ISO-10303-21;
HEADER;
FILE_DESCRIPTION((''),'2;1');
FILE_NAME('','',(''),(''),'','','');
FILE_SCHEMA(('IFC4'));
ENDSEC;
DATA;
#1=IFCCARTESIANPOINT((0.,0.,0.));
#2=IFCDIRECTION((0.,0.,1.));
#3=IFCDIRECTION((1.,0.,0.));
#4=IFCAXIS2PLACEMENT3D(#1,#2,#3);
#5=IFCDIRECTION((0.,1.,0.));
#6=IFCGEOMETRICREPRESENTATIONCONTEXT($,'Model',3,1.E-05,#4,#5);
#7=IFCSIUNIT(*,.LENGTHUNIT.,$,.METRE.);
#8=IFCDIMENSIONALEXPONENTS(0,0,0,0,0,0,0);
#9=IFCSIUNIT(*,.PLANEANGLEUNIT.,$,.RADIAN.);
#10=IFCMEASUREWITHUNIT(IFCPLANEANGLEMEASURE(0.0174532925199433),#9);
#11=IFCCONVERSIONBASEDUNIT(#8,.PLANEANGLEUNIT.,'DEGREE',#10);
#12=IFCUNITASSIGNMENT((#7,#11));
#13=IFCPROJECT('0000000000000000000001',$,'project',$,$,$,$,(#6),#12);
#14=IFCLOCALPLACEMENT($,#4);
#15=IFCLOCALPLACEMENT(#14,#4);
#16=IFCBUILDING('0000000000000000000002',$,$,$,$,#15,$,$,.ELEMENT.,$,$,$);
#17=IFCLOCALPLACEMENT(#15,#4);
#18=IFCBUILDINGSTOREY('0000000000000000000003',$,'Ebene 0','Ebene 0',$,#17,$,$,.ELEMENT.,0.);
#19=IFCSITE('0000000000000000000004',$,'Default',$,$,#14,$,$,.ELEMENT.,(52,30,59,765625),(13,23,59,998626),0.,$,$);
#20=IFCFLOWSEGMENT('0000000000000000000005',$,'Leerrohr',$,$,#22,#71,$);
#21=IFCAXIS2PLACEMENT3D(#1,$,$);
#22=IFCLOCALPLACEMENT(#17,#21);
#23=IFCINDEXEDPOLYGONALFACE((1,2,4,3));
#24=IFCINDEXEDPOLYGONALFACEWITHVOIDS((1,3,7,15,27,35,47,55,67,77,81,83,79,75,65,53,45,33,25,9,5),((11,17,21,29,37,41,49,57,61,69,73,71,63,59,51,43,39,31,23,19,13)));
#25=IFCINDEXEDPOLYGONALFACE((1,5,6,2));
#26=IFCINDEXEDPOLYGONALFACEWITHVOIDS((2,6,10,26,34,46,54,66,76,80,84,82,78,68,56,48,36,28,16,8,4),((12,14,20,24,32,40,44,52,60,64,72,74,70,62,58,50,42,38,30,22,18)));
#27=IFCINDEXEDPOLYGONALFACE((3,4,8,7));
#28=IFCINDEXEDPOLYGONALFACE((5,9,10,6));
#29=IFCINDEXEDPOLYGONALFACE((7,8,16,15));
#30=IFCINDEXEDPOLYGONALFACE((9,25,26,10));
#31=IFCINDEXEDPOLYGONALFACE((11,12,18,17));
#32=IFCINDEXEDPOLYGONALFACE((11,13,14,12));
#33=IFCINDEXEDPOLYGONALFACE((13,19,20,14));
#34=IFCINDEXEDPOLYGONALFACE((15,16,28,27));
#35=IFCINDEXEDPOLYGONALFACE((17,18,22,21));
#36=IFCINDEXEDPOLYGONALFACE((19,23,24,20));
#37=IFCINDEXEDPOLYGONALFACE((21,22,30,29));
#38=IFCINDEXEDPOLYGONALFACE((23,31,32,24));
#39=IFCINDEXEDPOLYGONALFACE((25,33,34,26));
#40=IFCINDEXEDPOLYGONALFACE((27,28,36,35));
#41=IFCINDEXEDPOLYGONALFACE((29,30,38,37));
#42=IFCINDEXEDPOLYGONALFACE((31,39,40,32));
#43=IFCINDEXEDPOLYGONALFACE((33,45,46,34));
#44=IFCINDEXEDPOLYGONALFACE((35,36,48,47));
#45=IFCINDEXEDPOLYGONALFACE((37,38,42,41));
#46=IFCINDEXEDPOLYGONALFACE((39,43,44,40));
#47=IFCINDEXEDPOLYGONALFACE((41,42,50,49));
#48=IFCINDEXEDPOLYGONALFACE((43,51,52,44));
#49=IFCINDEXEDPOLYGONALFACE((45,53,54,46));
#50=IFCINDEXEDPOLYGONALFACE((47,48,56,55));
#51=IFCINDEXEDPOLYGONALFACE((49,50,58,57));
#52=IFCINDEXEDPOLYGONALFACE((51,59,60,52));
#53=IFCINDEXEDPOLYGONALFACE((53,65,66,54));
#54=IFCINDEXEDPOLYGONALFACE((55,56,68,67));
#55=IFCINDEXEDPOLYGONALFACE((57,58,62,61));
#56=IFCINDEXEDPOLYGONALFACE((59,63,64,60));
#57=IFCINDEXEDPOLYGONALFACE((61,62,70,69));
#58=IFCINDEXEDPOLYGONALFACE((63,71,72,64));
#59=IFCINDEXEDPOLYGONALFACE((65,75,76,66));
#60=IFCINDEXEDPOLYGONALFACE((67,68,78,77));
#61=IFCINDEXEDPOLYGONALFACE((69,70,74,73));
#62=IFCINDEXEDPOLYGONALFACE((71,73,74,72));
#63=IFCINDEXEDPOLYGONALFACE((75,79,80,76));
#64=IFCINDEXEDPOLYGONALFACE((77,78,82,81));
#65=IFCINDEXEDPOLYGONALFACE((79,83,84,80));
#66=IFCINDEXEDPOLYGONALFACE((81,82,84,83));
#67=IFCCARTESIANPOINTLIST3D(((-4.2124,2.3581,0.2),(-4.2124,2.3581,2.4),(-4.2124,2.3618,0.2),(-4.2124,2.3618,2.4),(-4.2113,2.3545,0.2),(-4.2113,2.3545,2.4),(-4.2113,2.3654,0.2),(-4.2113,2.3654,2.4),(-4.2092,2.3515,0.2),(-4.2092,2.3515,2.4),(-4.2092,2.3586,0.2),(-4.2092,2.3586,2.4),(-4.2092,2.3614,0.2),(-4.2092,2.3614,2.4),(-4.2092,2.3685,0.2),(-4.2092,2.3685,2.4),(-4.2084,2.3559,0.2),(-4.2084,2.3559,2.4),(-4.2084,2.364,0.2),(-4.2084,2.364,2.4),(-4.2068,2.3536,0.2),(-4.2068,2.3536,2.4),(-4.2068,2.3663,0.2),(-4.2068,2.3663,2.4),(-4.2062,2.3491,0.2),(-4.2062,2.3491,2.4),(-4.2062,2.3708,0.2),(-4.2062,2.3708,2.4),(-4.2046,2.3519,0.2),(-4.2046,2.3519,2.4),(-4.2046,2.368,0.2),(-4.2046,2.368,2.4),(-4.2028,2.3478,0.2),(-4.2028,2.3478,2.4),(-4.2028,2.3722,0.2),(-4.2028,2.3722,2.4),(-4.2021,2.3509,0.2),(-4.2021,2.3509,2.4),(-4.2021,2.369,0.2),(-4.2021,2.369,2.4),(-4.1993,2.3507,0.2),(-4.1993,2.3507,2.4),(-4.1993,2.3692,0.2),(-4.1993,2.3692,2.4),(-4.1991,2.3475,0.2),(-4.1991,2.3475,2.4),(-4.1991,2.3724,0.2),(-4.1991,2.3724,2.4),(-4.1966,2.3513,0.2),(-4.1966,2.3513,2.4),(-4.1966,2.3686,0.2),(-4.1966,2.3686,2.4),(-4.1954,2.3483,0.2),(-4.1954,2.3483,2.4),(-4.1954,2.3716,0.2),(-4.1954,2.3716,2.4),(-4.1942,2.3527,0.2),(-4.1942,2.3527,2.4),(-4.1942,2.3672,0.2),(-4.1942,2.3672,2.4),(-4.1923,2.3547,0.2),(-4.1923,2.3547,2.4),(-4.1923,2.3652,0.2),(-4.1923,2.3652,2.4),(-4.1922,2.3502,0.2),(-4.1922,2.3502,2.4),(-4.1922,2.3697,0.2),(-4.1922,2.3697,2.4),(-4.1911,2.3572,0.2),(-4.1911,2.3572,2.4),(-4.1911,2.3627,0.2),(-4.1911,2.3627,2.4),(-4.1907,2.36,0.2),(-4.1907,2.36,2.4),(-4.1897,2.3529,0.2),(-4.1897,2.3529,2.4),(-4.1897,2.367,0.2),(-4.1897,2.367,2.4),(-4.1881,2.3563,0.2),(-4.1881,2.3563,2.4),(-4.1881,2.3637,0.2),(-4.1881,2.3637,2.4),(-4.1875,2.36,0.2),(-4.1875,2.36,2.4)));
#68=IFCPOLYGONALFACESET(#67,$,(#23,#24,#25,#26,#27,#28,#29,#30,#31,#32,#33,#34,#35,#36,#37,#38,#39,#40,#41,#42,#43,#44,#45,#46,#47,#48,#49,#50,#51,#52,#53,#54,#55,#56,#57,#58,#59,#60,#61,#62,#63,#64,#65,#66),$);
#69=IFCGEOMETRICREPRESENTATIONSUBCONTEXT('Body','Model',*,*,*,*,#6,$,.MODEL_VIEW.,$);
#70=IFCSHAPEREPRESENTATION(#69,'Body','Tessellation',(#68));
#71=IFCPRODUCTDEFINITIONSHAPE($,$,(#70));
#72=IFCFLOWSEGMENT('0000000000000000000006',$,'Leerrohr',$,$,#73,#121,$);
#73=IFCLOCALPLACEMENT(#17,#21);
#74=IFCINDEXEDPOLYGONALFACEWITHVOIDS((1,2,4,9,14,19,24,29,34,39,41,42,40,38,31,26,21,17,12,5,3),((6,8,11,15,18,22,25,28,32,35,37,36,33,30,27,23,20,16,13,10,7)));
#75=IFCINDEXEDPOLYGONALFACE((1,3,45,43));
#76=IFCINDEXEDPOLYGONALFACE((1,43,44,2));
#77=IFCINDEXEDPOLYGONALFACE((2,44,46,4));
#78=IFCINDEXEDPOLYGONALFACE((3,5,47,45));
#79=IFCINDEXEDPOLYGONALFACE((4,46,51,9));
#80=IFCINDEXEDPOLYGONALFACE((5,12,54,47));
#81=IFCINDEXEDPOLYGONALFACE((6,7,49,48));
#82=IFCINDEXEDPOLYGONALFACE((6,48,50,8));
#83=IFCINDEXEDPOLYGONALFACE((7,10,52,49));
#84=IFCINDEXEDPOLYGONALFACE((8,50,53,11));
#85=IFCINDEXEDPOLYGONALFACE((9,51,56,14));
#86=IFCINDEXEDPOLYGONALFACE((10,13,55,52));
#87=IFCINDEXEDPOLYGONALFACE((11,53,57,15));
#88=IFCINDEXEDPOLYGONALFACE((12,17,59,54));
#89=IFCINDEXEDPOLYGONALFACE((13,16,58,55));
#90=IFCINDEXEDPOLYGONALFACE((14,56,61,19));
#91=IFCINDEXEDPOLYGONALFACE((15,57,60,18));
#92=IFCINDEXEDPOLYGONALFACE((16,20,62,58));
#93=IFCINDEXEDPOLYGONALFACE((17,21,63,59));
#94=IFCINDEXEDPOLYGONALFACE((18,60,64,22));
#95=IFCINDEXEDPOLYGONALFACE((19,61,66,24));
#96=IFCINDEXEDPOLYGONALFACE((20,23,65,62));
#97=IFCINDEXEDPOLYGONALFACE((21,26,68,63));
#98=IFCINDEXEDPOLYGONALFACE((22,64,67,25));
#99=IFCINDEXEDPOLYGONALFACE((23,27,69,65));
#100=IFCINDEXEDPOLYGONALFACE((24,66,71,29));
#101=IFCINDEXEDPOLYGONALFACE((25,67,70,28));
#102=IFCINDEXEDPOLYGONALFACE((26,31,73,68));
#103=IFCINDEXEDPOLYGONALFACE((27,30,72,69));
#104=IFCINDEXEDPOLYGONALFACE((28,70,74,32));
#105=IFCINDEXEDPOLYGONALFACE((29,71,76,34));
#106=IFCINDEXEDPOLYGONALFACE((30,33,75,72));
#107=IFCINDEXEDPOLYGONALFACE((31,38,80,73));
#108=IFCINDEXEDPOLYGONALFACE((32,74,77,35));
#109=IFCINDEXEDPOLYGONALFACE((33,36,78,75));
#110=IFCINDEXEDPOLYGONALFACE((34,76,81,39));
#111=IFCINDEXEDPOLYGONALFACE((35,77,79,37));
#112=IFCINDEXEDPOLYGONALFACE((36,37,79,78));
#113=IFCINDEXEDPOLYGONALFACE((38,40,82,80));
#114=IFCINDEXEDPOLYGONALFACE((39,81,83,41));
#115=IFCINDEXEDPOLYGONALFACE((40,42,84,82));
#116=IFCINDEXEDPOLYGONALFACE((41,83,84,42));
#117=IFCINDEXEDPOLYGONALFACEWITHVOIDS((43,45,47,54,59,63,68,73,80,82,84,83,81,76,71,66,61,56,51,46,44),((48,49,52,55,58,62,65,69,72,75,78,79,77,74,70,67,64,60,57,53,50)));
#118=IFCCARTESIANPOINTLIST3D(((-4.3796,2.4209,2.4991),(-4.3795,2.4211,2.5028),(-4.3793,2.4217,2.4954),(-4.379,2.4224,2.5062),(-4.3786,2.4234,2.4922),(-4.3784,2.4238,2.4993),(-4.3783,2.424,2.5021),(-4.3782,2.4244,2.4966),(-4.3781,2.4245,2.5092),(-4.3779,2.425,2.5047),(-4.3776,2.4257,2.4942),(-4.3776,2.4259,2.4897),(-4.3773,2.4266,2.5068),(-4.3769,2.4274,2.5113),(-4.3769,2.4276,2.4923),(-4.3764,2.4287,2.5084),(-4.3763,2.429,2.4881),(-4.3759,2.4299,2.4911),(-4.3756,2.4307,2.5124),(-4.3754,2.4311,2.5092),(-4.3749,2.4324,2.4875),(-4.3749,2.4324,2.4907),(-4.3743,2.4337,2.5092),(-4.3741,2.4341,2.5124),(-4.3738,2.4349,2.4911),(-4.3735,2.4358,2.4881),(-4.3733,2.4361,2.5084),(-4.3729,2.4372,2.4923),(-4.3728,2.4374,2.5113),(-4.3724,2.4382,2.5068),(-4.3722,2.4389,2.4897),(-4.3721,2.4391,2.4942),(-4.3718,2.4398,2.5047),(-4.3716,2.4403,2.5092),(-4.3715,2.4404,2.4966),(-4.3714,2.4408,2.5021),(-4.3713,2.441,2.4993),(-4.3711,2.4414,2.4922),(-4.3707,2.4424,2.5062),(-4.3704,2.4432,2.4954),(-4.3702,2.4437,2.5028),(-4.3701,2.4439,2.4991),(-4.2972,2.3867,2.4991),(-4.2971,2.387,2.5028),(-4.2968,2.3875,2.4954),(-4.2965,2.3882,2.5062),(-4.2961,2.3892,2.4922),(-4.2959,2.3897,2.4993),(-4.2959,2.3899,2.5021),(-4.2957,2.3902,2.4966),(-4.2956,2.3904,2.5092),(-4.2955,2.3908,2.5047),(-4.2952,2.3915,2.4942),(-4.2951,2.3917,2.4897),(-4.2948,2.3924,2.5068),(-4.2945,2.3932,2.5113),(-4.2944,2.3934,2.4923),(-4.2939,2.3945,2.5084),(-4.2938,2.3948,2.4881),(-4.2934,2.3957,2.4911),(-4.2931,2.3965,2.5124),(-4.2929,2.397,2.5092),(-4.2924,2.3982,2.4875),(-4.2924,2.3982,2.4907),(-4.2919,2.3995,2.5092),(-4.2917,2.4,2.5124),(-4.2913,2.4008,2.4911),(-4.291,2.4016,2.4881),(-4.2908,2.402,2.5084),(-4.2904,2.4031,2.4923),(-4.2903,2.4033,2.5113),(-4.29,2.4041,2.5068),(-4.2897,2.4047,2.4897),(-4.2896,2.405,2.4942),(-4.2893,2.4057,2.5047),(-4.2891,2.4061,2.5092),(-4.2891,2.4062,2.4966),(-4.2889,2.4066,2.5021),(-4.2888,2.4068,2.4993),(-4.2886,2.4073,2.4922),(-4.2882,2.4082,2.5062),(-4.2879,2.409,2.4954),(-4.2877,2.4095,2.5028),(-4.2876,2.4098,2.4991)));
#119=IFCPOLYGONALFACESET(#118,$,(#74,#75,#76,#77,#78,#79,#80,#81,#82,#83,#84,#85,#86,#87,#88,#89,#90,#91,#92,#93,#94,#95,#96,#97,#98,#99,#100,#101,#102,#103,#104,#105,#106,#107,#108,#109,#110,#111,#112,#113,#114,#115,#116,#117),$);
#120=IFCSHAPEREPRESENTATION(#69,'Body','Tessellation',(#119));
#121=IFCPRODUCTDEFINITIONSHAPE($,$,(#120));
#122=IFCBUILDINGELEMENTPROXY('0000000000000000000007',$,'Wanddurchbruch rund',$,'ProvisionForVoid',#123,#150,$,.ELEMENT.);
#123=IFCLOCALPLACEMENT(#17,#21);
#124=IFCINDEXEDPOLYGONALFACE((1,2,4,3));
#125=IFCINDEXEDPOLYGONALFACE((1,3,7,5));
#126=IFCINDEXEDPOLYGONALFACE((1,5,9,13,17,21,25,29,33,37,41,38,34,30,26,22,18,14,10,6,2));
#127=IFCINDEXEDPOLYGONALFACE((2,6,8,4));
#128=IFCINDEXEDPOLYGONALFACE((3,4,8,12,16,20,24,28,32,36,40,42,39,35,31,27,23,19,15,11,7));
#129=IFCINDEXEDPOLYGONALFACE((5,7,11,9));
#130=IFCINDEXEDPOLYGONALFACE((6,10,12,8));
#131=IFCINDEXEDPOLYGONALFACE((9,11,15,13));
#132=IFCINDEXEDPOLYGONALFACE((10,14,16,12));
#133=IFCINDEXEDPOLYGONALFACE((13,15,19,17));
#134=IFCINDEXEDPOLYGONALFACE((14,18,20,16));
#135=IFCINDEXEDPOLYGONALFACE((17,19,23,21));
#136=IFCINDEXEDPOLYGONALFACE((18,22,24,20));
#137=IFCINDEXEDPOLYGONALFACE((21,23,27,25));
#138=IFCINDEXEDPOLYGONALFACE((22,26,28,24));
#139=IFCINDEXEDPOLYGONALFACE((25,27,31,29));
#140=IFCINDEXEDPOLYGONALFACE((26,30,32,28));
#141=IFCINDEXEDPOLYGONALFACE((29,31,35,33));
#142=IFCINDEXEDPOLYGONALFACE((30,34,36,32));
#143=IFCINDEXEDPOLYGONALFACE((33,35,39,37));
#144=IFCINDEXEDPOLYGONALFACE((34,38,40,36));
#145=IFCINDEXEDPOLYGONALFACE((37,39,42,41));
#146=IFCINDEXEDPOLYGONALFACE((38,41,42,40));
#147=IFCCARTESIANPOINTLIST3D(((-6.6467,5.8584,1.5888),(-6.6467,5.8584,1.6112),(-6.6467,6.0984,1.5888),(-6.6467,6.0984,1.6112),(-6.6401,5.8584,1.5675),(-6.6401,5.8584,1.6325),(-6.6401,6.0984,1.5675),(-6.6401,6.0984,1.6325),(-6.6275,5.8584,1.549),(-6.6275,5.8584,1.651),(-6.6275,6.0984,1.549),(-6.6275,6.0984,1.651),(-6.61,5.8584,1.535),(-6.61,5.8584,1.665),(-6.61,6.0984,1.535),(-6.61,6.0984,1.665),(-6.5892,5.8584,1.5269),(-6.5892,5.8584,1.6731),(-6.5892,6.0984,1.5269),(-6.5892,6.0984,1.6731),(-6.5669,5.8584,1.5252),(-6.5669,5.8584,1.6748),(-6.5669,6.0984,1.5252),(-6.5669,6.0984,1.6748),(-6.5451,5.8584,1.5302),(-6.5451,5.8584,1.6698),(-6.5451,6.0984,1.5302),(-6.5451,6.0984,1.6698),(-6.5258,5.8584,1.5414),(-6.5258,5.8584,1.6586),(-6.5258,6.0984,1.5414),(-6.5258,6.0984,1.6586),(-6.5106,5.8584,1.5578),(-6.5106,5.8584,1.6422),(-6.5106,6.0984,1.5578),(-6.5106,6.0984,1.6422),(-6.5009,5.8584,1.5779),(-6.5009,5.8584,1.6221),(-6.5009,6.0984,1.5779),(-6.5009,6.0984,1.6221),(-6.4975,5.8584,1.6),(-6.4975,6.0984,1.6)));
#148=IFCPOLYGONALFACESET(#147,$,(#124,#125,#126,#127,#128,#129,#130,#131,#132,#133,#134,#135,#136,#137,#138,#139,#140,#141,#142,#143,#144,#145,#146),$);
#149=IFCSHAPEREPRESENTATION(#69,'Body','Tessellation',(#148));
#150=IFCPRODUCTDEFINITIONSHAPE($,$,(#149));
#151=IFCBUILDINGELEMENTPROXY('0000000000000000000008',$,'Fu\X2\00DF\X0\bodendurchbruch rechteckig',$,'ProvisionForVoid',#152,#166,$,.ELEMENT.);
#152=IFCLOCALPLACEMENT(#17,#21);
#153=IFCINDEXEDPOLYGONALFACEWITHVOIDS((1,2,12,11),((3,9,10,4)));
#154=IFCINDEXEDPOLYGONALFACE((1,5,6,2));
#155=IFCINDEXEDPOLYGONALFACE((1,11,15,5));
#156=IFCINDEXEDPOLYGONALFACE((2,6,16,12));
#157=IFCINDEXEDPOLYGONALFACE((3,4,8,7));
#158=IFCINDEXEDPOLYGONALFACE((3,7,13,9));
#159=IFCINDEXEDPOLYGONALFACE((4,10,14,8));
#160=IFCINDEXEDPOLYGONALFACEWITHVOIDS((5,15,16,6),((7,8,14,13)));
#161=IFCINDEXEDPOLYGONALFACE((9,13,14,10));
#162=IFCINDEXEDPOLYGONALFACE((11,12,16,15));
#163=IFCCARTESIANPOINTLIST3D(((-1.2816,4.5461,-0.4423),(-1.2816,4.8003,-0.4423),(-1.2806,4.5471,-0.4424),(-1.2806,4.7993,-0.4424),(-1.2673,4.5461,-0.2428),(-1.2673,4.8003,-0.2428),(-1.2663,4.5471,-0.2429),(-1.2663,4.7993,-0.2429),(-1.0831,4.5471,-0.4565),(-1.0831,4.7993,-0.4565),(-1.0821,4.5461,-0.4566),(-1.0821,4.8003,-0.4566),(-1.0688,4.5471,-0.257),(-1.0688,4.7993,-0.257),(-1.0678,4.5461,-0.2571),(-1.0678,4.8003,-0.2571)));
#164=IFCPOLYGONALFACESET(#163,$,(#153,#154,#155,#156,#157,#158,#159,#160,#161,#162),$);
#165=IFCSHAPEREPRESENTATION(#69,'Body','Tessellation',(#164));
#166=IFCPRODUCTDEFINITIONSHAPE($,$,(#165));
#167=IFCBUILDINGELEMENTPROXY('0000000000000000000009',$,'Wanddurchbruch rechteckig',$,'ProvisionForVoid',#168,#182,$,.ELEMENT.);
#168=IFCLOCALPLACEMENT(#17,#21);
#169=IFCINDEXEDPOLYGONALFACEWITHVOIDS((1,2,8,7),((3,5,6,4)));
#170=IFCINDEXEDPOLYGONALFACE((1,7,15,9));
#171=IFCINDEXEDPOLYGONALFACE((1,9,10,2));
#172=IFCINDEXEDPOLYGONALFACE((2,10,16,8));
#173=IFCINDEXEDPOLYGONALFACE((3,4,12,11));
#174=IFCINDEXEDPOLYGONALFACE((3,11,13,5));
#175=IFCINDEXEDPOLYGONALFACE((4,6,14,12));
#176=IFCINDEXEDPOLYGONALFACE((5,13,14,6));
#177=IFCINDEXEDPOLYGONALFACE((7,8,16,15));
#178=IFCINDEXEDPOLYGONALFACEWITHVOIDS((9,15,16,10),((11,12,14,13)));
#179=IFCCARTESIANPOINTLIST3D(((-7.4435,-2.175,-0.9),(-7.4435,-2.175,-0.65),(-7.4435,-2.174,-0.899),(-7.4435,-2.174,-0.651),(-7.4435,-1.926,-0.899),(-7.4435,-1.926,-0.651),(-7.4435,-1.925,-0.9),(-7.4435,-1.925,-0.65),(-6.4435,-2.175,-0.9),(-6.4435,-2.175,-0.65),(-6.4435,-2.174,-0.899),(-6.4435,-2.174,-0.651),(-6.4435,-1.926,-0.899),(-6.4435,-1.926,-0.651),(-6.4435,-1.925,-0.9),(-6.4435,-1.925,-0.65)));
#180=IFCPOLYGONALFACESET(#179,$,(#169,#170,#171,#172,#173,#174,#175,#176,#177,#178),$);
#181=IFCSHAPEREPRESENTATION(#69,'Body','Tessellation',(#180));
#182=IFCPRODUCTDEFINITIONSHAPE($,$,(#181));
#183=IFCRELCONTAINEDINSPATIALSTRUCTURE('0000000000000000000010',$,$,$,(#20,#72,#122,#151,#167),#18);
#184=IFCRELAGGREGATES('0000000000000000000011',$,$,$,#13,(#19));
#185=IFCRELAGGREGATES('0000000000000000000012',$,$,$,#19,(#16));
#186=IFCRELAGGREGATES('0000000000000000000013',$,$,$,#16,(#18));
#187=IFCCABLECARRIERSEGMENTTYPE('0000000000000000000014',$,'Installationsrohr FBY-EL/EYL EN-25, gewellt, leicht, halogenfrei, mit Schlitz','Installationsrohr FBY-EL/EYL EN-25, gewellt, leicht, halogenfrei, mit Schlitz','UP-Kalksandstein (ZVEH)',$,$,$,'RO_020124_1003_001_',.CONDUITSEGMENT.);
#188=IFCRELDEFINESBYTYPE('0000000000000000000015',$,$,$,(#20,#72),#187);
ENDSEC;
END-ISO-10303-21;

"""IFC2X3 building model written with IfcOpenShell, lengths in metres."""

from ifc_helpers import new_model, entity, si_unit, converted_unit, direction, frame, origin_with_axes, origin_2d_with_axis, place, context, subcontext, project, spatial, hollow_rectangle, circle, hollow_circle, extrude, source, transform, mapped, type_object, element, save


model = new_model("IFC2X3")

# Units and contexts
model_context = context("Model", 3, precision=1e-05, world=origin_with_axes(), true_north=direction((0.0, 1.0, 0.0)))
body_context = subcontext(model_context, "Body", "Model", "MODEL_VIEW")
ifc_project = project(units=[si_unit("LENGTHUNIT", "METRE"), converted_unit("PLANEANGLEUNIT", "DEGREE", entity("IfcPlaneAngleMeasure", 0.0174532925199433), si_unit("PLANEANGLEUNIT", "RADIAN"), dimensions=[0, 0, 0, 0, 0, 0, 0])], contexts=[model_context])

# Site, building, storey
site_placement = place(None, origin_with_axes())
site = spatial("IfcSite", under=ifc_project, at=site_placement, Name="Default", CompositionType="ELEMENT", RefLatitude=(52, 30, 59, 765625), RefLongitude=(13, 23, 59, 998626), RefElevation=0.0)
building_placement = place(site_placement, origin_with_axes())
building = spatial("IfcBuilding", under=site, at=building_placement, CompositionType="ELEMENT")
storey_placement = place(building_placement, origin_with_axes())
storey = spatial("IfcBuildingStorey", under=building, at=storey_placement, Name="Ebene 0", Description="Ebene 0", CompositionType="ELEMENT", Elevation=0.0)

# Flow segments
cable_carrier_segment_type_1 = type_object("IfcCableCarrierSegmentType", Name="Installationsrohr FBY-EL/EYL EN-25, gewellt, leicht, halogenfrei, mit Schlitz", Description="Installationsrohr FBY-EL/EYL EN-25, gewellt, leicht, halogenfrei, mit Schlitz", ApplicableOccurrence="UP-Kalksandstein (ZVEH)", ElementType="RO_020124_1003_001_", PredefinedType="CONDUITSEGMENT")
flow_segment_1_placement = place(storey_placement, frame((-4.2, 2.36, 0.2), z_axis=(-1.0, 0.0, 0.0), x_axis=(0.0, 0.0, 1.0)))
element("IfcFlowSegment", 1, at=flow_segment_1_placement, inside=storey, type_object=cable_carrier_segment_type_1, Name="Leerrohr", context=body_context, shape_type="SweptSolid", body=[
    extrude(hollow_circle(Radius=0.0125, WallThickness=0.0032, at=origin_2d_with_axis()), frame((0.0, 0.0, 0.0), z_axis=(1.0, 0.0, 0.0), x_axis=(0.0, 0.0, -1.0)), (0.0, 0.0, 1.0), 2.2),
])
flow_segment_2_placement = place(storey_placement, frame((-4.2924, 2.3982, 2.5), z_axis=(0.0, 0.0, 1.0), x_axis=(-0.92388, 0.382683, 0.0)))
element("IfcFlowSegment", 2, at=flow_segment_2_placement, inside=storey, type_object=cable_carrier_segment_type_1, Name="Leerrohr", context=body_context, shape_type="SweptSolid", body=[
    extrude(hollow_circle(Radius=0.0125, WallThickness=0.0032, at=origin_2d_with_axis()), frame((0.0, 0.0, 0.0), z_axis=(1.0, 0.0, 0.0), x_axis=(0.0, 0.0, -1.0)), (0.0, 0.0, 1.0), 0.0893),
])

# Building element proxies
shared_shape_1 = source(origin_with_axes(), body_context, "Body", "SweptSolid", [
    extrude(circle(Radius=0.075, at=origin_2d_with_axis()), frame((0.075, 0.0, -0.075), z_axis=(0.0, -1.0, 0.0), x_axis=(1.0, 0.0, 0.0)), (0.0, 0.0, -1.0), 0.24),
])
proxy_1_placement = place(storey_placement, frame((-6.6475, 5.8584, 1.675), z_axis=(0.0, 0.0, 1.0), x_axis=(1.0, 0.0, 0.0)))
element("IfcBuildingElementProxy", 3, at=proxy_1_placement, inside=storey, Name="Wanddurchbruch rund", ObjectType="ProvisionForVoid", CompositionType="ELEMENT", context=body_context, shape_type="MappedRepresentation", body=[
    mapped(shared_shape_1, transform((0.0, 0.0, 0.0), x_axis=(1.0, 0.0, 0.0), y_axis=(0.0, 1.0, 0.0), z_axis=(0.0, 0.0, 1.0), scale=1.0)),
])
shared_shape_2 = source(origin_with_axes(), body_context, "Body", "SweptSolid", [
    extrude(hollow_rectangle(XDim=0.2, YDim=0.2542, WallThickness=0.001, at=origin_2d_with_axis()), frame((0.1, 0.1271, -0.2), z_axis=(0.0, 0.0, 1.0), x_axis=(1.0, 0.0, 0.0)), (0.0, 0.0, 1.0), 0.2),
])
proxy_2_placement = place(storey_placement, frame((-1.2673, 4.5461, -0.2428), z_axis=(0.071497, 0.0, 0.997441), x_axis=(0.997441, 0.0, -0.071497)))
element("IfcBuildingElementProxy", 4, at=proxy_2_placement, inside=storey, Name="Fußbodendurchbruch rechteckig", ObjectType="ProvisionForVoid", CompositionType="ELEMENT", context=body_context, shape_type="MappedRepresentation", body=[
    mapped(shared_shape_2, transform((0.0, 0.0, 0.0), x_axis=(1.0, 0.0, 0.0), y_axis=(0.0, 1.0, 0.0), z_axis=(0.0, 0.0, 1.0), scale=1.0)),
])
shared_shape_3 = source(origin_with_axes(), body_context, "Body", "SweptSolid", [
    extrude(hollow_rectangle(XDim=0.25, YDim=0.25, WallThickness=0.001, at=origin_2d_with_axis()), frame((0.125, 1.0, -0.125), z_axis=(0.0, -1.0, 0.0), x_axis=(1.0, 0.0, 0.0)), (0.0, 0.0, 1.0), 1.0),
])
proxy_3_placement = place(storey_placement, frame((-7.4435, -1.925, -0.65), z_axis=(0.0, 0.0, 1.0), x_axis=(0.0, -1.0, 0.0)))
element("IfcBuildingElementProxy", 5, at=proxy_3_placement, inside=storey, Name="Wanddurchbruch rechteckig", ObjectType="ProvisionForVoid", CompositionType="ELEMENT", context=body_context, shape_type="MappedRepresentation", body=[
    mapped(shared_shape_3, transform((0.0, 0.0, 0.0), x_axis=(1.0, 0.0, 0.0), y_axis=(0.0, 1.0, 0.0), z_axis=(0.0, 0.0, 1.0), scale=1.0)),
])

save(model, "model.ifc")
